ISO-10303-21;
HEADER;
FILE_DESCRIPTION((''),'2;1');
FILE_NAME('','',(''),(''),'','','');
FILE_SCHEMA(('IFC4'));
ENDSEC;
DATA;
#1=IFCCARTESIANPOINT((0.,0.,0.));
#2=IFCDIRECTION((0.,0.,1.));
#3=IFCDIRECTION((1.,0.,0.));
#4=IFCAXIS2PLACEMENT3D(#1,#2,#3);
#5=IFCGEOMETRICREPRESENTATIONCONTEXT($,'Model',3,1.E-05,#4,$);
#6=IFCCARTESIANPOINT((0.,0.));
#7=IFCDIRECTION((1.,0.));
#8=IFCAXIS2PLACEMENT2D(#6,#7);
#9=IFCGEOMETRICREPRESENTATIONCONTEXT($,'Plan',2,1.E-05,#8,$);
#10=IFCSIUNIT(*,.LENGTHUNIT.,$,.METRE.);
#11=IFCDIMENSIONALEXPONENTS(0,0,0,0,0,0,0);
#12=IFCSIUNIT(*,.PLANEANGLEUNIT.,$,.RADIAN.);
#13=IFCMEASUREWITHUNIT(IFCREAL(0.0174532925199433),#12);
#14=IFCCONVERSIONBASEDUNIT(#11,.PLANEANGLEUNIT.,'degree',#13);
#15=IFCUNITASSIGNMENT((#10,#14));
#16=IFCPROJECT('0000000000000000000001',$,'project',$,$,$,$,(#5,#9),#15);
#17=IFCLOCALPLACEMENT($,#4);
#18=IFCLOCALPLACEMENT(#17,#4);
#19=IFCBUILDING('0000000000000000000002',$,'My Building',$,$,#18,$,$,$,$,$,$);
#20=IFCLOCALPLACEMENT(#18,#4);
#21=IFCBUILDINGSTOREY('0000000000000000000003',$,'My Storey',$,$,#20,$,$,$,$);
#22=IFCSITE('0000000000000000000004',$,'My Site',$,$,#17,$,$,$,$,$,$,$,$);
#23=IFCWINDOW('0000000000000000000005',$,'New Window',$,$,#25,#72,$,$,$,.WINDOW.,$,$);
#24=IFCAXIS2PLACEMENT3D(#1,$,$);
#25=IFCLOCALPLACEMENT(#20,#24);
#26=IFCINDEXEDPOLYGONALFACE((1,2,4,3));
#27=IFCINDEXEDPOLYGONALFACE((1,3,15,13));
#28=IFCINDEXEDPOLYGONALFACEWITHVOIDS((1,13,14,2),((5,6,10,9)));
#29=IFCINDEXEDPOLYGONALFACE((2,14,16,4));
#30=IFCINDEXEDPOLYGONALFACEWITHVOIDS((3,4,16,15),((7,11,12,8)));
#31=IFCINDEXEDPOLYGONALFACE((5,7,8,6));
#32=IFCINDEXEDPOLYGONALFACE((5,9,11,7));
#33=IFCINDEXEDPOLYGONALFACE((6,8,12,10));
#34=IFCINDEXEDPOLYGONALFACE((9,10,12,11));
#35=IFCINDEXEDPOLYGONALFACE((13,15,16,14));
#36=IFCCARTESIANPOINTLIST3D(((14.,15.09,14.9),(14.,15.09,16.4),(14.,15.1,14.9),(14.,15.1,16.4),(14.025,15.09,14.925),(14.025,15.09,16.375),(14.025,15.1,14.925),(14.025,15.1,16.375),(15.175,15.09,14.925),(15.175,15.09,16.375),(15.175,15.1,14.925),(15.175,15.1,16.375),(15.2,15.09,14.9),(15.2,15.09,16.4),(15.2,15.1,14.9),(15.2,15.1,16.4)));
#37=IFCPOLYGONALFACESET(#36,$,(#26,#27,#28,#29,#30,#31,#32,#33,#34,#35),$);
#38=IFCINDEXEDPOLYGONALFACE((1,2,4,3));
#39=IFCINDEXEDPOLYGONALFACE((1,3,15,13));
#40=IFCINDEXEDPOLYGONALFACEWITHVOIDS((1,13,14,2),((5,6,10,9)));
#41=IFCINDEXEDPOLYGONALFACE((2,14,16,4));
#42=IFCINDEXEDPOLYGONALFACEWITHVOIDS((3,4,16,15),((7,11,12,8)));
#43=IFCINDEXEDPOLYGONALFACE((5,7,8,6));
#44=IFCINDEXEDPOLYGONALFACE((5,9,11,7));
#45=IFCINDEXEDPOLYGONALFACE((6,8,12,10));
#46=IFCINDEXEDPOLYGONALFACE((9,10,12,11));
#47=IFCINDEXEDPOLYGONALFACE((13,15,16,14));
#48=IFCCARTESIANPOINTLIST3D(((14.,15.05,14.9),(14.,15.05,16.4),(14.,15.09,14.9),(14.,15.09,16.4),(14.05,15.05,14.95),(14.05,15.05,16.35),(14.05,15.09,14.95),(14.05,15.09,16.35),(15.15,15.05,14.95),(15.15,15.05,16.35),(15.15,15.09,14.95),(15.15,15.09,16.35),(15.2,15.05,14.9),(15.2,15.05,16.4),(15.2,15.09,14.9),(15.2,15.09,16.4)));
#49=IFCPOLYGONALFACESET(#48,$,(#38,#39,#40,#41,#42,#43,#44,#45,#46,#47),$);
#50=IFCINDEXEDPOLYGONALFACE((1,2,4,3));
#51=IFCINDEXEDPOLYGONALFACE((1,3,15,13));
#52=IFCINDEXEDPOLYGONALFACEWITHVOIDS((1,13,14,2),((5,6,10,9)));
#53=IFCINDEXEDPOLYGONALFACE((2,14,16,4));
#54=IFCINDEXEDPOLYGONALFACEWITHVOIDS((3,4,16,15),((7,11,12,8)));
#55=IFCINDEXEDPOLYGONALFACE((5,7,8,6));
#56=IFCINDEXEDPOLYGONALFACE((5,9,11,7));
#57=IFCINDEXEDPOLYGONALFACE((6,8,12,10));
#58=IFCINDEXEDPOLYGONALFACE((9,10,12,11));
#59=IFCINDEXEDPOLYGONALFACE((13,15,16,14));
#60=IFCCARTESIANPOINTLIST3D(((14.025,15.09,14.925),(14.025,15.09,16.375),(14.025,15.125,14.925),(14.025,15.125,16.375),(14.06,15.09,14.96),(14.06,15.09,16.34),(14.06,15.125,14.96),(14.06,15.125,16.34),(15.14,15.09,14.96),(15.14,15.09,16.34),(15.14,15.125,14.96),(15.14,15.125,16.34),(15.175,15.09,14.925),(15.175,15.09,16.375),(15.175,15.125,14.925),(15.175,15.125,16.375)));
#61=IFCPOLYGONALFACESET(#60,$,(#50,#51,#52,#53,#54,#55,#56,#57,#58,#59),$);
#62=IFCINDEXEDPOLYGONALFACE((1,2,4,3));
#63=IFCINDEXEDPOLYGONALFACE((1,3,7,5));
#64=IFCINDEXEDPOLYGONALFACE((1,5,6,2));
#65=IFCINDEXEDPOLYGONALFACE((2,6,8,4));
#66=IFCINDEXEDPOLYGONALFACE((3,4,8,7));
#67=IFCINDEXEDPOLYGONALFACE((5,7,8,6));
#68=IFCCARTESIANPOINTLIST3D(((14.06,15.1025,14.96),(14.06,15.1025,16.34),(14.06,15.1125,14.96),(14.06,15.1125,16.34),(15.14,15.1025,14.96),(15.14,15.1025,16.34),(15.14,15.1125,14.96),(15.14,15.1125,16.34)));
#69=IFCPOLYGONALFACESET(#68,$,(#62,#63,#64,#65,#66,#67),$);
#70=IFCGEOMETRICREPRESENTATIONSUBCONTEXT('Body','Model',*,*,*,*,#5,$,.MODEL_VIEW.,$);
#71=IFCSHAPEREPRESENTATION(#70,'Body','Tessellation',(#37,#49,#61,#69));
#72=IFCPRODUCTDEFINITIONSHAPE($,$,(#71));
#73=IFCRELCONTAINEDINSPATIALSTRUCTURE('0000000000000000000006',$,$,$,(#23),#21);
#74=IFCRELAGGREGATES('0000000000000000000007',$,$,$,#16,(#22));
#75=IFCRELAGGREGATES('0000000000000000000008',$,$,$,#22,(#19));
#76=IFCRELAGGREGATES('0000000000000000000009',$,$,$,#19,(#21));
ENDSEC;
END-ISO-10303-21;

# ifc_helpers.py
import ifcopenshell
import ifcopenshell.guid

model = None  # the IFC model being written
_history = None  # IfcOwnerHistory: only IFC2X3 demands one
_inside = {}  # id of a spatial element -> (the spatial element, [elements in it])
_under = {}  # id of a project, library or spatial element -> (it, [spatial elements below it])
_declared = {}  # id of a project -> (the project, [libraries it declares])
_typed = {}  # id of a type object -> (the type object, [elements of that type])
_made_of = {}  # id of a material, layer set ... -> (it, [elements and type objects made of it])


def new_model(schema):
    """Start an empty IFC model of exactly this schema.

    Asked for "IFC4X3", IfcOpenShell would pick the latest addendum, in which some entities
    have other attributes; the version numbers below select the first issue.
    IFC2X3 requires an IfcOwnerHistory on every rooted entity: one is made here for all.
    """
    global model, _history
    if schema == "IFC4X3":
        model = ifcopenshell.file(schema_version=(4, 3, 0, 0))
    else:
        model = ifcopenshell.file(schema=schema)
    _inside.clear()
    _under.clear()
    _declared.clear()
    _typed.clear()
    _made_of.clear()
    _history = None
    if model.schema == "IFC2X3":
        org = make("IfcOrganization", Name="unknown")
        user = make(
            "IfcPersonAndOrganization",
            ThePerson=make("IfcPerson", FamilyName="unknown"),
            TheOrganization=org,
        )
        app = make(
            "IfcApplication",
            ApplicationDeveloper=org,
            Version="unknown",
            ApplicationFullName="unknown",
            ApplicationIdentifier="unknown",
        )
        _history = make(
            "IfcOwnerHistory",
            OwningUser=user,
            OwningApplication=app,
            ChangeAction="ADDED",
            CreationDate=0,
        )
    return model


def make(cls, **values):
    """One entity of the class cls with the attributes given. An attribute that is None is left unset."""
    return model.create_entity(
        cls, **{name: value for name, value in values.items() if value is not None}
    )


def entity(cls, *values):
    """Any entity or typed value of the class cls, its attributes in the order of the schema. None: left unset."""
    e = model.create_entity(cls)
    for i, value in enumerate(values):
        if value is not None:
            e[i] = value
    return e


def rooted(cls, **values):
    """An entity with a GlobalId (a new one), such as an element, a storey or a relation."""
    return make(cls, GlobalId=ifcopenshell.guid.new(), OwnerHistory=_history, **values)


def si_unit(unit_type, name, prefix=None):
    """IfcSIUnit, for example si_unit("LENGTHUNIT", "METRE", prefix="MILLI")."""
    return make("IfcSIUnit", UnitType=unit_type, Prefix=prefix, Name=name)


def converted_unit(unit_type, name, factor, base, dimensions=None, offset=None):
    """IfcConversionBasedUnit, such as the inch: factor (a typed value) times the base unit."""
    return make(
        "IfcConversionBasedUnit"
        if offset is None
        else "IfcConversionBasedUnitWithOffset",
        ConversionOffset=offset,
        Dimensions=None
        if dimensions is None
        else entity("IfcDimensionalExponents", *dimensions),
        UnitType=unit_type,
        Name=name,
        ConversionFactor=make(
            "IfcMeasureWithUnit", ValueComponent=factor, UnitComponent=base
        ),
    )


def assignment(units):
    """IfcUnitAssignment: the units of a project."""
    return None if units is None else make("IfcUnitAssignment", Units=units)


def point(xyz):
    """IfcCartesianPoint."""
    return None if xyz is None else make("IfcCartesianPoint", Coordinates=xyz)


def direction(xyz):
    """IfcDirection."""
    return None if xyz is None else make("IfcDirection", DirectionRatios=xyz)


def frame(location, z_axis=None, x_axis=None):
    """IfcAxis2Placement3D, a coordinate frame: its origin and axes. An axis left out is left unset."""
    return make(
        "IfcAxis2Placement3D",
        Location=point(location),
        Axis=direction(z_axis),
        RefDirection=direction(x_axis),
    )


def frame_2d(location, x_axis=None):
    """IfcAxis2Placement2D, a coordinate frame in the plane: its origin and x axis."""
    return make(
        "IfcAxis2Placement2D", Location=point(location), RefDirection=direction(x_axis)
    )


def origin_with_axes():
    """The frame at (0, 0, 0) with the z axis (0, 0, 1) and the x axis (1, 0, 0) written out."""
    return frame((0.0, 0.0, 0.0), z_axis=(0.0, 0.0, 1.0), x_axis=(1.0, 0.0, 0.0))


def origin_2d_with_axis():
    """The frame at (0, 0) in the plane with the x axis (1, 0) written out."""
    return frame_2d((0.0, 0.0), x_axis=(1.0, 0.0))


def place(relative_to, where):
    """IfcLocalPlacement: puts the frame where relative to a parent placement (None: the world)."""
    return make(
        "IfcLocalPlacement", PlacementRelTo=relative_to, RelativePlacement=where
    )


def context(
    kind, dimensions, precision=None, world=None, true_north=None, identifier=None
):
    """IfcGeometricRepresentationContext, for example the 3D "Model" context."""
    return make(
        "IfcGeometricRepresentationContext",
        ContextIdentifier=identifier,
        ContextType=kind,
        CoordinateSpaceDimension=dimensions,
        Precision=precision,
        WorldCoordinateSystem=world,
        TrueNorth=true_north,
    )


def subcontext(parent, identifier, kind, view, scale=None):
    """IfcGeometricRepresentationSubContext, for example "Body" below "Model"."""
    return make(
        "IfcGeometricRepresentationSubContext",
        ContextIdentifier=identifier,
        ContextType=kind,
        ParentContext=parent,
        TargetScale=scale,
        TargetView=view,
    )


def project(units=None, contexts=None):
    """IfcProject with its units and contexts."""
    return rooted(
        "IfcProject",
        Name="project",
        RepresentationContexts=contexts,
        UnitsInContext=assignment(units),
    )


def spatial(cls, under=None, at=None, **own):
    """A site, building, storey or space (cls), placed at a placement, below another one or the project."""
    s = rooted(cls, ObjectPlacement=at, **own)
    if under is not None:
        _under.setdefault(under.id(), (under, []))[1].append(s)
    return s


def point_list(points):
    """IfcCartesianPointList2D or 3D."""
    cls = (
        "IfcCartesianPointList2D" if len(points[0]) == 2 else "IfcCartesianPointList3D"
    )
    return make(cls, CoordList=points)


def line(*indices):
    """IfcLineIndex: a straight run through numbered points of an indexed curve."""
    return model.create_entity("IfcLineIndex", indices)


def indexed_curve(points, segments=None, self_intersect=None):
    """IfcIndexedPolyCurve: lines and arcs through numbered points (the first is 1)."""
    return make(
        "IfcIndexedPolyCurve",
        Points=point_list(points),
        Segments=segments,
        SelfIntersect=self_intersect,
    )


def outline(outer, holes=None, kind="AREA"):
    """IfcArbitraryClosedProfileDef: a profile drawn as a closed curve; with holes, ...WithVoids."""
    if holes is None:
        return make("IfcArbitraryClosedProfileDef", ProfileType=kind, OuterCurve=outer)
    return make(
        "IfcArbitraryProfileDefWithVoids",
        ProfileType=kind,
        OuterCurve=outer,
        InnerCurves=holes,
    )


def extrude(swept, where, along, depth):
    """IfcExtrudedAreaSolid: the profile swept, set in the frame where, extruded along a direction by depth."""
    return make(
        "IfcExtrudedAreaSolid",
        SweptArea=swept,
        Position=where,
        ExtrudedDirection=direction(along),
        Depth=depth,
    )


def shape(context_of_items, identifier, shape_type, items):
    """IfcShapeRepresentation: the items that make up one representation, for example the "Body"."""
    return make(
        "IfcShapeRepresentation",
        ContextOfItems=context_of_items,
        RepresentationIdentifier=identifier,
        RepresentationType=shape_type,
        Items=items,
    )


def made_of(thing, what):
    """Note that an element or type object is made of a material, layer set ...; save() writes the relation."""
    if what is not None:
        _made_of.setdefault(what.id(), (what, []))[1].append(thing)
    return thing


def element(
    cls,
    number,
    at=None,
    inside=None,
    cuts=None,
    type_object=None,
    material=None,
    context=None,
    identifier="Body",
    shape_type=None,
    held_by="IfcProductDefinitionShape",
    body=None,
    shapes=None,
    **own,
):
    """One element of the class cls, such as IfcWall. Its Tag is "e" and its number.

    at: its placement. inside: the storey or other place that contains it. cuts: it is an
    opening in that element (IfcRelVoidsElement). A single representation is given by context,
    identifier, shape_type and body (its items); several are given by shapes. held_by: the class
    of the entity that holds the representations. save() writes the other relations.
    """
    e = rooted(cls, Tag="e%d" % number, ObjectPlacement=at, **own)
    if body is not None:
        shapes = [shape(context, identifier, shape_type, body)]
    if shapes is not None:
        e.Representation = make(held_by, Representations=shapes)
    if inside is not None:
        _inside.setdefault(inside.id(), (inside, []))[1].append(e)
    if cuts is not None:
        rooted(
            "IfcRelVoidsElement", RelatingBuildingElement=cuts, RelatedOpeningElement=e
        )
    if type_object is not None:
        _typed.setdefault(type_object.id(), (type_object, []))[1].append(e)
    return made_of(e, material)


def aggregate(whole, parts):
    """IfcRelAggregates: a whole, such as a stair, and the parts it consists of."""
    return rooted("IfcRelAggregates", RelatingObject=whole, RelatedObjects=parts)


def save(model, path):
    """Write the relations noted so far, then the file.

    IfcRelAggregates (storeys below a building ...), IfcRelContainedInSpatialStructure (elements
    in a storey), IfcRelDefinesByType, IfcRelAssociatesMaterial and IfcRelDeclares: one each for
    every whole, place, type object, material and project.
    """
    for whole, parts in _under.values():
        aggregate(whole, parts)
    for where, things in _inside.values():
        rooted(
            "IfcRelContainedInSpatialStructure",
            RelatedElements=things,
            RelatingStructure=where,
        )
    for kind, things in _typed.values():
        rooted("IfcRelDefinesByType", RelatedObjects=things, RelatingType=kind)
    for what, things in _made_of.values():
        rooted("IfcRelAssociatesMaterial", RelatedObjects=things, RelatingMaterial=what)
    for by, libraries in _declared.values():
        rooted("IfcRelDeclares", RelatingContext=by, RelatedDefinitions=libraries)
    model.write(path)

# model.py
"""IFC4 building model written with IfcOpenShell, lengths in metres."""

from ifc_helpers import new_model, entity, si_unit, converted_unit, frame, origin_with_axes, origin_2d_with_axis, place, context, subcontext, project, spatial, line, indexed_curve, outline, extrude, element, save


model = new_model("IFC4")

# Units and contexts
model_context = context("Model", 3, precision=1e-05, world=origin_with_axes())
plan_context = context("Plan", 2, precision=1e-05, world=origin_2d_with_axis())
body_context = subcontext(model_context, "Body", "Model", "MODEL_VIEW")
ifc_project = project(units=[si_unit("LENGTHUNIT", "METRE"), converted_unit("PLANEANGLEUNIT", "degree", entity("IfcReal", 0.0174532925199433), si_unit("PLANEANGLEUNIT", "RADIAN"), dimensions=[0, 0, 0, 0, 0, 0, 0])], contexts=[model_context, plan_context])

# Site, building, storey
site_placement = place(None, origin_with_axes())
site = spatial("IfcSite", under=ifc_project, at=site_placement, Name="My Site")
building_placement = place(site_placement, origin_with_axes())
building = spatial("IfcBuilding", under=site, at=building_placement, Name="My Building")
storey_placement = place(building_placement, origin_with_axes())
storey = spatial("IfcBuildingStorey", under=building, at=storey_placement, Name="My Storey")

# Window
for number, where, z_axis, x_axis, name in (
    (1, (14.0, 15.0, 14.9), (0.0, 0.0, 1.0), (1.0, 0.0, 0.0), "New Window"),
):
    element("IfcWindow", number, at=place(storey_placement, frame(where, z_axis=z_axis, x_axis=x_axis)), inside=storey, Name=name, PredefinedType="WINDOW", context=body_context, shape_type="SweptSolid", body=[
        extrude(outline(indexed_curve([(0.0, 0.0), (1.2, 0.0), (1.2, 1.5), (0.0, 1.5)], segments=[line(1, 2, 3, 4, 1)]), holes=[indexed_curve([(0.025, 0.025), (1.175, 0.025), (1.175, 1.475), (0.025, 1.475)], segments=[line(1, 2, 3, 4, 1)])]), frame((0.0, 0.09, 0.0), z_axis=(0.0, -1.0, 0.0), x_axis=(1.0, 0.0, 0.0)), (0.0, 0.0, -1.0), 0.01),
        extrude(outline(indexed_curve([(0.0, 0.0), (1.2, 0.0), (1.2, 1.5), (0.0, 1.5)], segments=[line(1, 2, 3, 4, 1)]), holes=[indexed_curve([(0.05, 0.05), (1.15, 0.05), (1.15, 1.45), (0.05, 1.45)], segments=[line(1, 2, 3, 4, 1)])]), frame((0.0, 0.05, 0.0), z_axis=(0.0, -1.0, 0.0), x_axis=(1.0, 0.0, 0.0)), (0.0, 0.0, -1.0), 0.04),
        extrude(outline(indexed_curve([(0.0, 0.0), (1.15, 0.0), (1.15, 1.45), (0.0, 1.45)], segments=[line(1, 2, 3, 4, 1)]), holes=[indexed_curve([(0.035, 0.035), (1.115, 0.035), (1.115, 1.415), (0.035, 1.415)], segments=[line(1, 2, 3, 4, 1)])]), frame((0.025, 0.09, 0.025), z_axis=(0.0, -1.0, 0.0), x_axis=(1.0, 0.0, 0.0)), (0.0, 0.0, -1.0), 0.035),
        extrude(outline(indexed_curve([(0.035, 0.035), (1.115, 0.035), (1.115, 1.415), (0.035, 1.415)], segments=[line(1, 2, 3, 4, 1)])), frame((0.025, 0.1025, 0.025), z_axis=(0.0, -1.0, 0.0), x_axis=(1.0, 0.0, 0.0)), (0.0, 0.0, -1.0), 0.01),
    ])

save(model, "model.ifc")
